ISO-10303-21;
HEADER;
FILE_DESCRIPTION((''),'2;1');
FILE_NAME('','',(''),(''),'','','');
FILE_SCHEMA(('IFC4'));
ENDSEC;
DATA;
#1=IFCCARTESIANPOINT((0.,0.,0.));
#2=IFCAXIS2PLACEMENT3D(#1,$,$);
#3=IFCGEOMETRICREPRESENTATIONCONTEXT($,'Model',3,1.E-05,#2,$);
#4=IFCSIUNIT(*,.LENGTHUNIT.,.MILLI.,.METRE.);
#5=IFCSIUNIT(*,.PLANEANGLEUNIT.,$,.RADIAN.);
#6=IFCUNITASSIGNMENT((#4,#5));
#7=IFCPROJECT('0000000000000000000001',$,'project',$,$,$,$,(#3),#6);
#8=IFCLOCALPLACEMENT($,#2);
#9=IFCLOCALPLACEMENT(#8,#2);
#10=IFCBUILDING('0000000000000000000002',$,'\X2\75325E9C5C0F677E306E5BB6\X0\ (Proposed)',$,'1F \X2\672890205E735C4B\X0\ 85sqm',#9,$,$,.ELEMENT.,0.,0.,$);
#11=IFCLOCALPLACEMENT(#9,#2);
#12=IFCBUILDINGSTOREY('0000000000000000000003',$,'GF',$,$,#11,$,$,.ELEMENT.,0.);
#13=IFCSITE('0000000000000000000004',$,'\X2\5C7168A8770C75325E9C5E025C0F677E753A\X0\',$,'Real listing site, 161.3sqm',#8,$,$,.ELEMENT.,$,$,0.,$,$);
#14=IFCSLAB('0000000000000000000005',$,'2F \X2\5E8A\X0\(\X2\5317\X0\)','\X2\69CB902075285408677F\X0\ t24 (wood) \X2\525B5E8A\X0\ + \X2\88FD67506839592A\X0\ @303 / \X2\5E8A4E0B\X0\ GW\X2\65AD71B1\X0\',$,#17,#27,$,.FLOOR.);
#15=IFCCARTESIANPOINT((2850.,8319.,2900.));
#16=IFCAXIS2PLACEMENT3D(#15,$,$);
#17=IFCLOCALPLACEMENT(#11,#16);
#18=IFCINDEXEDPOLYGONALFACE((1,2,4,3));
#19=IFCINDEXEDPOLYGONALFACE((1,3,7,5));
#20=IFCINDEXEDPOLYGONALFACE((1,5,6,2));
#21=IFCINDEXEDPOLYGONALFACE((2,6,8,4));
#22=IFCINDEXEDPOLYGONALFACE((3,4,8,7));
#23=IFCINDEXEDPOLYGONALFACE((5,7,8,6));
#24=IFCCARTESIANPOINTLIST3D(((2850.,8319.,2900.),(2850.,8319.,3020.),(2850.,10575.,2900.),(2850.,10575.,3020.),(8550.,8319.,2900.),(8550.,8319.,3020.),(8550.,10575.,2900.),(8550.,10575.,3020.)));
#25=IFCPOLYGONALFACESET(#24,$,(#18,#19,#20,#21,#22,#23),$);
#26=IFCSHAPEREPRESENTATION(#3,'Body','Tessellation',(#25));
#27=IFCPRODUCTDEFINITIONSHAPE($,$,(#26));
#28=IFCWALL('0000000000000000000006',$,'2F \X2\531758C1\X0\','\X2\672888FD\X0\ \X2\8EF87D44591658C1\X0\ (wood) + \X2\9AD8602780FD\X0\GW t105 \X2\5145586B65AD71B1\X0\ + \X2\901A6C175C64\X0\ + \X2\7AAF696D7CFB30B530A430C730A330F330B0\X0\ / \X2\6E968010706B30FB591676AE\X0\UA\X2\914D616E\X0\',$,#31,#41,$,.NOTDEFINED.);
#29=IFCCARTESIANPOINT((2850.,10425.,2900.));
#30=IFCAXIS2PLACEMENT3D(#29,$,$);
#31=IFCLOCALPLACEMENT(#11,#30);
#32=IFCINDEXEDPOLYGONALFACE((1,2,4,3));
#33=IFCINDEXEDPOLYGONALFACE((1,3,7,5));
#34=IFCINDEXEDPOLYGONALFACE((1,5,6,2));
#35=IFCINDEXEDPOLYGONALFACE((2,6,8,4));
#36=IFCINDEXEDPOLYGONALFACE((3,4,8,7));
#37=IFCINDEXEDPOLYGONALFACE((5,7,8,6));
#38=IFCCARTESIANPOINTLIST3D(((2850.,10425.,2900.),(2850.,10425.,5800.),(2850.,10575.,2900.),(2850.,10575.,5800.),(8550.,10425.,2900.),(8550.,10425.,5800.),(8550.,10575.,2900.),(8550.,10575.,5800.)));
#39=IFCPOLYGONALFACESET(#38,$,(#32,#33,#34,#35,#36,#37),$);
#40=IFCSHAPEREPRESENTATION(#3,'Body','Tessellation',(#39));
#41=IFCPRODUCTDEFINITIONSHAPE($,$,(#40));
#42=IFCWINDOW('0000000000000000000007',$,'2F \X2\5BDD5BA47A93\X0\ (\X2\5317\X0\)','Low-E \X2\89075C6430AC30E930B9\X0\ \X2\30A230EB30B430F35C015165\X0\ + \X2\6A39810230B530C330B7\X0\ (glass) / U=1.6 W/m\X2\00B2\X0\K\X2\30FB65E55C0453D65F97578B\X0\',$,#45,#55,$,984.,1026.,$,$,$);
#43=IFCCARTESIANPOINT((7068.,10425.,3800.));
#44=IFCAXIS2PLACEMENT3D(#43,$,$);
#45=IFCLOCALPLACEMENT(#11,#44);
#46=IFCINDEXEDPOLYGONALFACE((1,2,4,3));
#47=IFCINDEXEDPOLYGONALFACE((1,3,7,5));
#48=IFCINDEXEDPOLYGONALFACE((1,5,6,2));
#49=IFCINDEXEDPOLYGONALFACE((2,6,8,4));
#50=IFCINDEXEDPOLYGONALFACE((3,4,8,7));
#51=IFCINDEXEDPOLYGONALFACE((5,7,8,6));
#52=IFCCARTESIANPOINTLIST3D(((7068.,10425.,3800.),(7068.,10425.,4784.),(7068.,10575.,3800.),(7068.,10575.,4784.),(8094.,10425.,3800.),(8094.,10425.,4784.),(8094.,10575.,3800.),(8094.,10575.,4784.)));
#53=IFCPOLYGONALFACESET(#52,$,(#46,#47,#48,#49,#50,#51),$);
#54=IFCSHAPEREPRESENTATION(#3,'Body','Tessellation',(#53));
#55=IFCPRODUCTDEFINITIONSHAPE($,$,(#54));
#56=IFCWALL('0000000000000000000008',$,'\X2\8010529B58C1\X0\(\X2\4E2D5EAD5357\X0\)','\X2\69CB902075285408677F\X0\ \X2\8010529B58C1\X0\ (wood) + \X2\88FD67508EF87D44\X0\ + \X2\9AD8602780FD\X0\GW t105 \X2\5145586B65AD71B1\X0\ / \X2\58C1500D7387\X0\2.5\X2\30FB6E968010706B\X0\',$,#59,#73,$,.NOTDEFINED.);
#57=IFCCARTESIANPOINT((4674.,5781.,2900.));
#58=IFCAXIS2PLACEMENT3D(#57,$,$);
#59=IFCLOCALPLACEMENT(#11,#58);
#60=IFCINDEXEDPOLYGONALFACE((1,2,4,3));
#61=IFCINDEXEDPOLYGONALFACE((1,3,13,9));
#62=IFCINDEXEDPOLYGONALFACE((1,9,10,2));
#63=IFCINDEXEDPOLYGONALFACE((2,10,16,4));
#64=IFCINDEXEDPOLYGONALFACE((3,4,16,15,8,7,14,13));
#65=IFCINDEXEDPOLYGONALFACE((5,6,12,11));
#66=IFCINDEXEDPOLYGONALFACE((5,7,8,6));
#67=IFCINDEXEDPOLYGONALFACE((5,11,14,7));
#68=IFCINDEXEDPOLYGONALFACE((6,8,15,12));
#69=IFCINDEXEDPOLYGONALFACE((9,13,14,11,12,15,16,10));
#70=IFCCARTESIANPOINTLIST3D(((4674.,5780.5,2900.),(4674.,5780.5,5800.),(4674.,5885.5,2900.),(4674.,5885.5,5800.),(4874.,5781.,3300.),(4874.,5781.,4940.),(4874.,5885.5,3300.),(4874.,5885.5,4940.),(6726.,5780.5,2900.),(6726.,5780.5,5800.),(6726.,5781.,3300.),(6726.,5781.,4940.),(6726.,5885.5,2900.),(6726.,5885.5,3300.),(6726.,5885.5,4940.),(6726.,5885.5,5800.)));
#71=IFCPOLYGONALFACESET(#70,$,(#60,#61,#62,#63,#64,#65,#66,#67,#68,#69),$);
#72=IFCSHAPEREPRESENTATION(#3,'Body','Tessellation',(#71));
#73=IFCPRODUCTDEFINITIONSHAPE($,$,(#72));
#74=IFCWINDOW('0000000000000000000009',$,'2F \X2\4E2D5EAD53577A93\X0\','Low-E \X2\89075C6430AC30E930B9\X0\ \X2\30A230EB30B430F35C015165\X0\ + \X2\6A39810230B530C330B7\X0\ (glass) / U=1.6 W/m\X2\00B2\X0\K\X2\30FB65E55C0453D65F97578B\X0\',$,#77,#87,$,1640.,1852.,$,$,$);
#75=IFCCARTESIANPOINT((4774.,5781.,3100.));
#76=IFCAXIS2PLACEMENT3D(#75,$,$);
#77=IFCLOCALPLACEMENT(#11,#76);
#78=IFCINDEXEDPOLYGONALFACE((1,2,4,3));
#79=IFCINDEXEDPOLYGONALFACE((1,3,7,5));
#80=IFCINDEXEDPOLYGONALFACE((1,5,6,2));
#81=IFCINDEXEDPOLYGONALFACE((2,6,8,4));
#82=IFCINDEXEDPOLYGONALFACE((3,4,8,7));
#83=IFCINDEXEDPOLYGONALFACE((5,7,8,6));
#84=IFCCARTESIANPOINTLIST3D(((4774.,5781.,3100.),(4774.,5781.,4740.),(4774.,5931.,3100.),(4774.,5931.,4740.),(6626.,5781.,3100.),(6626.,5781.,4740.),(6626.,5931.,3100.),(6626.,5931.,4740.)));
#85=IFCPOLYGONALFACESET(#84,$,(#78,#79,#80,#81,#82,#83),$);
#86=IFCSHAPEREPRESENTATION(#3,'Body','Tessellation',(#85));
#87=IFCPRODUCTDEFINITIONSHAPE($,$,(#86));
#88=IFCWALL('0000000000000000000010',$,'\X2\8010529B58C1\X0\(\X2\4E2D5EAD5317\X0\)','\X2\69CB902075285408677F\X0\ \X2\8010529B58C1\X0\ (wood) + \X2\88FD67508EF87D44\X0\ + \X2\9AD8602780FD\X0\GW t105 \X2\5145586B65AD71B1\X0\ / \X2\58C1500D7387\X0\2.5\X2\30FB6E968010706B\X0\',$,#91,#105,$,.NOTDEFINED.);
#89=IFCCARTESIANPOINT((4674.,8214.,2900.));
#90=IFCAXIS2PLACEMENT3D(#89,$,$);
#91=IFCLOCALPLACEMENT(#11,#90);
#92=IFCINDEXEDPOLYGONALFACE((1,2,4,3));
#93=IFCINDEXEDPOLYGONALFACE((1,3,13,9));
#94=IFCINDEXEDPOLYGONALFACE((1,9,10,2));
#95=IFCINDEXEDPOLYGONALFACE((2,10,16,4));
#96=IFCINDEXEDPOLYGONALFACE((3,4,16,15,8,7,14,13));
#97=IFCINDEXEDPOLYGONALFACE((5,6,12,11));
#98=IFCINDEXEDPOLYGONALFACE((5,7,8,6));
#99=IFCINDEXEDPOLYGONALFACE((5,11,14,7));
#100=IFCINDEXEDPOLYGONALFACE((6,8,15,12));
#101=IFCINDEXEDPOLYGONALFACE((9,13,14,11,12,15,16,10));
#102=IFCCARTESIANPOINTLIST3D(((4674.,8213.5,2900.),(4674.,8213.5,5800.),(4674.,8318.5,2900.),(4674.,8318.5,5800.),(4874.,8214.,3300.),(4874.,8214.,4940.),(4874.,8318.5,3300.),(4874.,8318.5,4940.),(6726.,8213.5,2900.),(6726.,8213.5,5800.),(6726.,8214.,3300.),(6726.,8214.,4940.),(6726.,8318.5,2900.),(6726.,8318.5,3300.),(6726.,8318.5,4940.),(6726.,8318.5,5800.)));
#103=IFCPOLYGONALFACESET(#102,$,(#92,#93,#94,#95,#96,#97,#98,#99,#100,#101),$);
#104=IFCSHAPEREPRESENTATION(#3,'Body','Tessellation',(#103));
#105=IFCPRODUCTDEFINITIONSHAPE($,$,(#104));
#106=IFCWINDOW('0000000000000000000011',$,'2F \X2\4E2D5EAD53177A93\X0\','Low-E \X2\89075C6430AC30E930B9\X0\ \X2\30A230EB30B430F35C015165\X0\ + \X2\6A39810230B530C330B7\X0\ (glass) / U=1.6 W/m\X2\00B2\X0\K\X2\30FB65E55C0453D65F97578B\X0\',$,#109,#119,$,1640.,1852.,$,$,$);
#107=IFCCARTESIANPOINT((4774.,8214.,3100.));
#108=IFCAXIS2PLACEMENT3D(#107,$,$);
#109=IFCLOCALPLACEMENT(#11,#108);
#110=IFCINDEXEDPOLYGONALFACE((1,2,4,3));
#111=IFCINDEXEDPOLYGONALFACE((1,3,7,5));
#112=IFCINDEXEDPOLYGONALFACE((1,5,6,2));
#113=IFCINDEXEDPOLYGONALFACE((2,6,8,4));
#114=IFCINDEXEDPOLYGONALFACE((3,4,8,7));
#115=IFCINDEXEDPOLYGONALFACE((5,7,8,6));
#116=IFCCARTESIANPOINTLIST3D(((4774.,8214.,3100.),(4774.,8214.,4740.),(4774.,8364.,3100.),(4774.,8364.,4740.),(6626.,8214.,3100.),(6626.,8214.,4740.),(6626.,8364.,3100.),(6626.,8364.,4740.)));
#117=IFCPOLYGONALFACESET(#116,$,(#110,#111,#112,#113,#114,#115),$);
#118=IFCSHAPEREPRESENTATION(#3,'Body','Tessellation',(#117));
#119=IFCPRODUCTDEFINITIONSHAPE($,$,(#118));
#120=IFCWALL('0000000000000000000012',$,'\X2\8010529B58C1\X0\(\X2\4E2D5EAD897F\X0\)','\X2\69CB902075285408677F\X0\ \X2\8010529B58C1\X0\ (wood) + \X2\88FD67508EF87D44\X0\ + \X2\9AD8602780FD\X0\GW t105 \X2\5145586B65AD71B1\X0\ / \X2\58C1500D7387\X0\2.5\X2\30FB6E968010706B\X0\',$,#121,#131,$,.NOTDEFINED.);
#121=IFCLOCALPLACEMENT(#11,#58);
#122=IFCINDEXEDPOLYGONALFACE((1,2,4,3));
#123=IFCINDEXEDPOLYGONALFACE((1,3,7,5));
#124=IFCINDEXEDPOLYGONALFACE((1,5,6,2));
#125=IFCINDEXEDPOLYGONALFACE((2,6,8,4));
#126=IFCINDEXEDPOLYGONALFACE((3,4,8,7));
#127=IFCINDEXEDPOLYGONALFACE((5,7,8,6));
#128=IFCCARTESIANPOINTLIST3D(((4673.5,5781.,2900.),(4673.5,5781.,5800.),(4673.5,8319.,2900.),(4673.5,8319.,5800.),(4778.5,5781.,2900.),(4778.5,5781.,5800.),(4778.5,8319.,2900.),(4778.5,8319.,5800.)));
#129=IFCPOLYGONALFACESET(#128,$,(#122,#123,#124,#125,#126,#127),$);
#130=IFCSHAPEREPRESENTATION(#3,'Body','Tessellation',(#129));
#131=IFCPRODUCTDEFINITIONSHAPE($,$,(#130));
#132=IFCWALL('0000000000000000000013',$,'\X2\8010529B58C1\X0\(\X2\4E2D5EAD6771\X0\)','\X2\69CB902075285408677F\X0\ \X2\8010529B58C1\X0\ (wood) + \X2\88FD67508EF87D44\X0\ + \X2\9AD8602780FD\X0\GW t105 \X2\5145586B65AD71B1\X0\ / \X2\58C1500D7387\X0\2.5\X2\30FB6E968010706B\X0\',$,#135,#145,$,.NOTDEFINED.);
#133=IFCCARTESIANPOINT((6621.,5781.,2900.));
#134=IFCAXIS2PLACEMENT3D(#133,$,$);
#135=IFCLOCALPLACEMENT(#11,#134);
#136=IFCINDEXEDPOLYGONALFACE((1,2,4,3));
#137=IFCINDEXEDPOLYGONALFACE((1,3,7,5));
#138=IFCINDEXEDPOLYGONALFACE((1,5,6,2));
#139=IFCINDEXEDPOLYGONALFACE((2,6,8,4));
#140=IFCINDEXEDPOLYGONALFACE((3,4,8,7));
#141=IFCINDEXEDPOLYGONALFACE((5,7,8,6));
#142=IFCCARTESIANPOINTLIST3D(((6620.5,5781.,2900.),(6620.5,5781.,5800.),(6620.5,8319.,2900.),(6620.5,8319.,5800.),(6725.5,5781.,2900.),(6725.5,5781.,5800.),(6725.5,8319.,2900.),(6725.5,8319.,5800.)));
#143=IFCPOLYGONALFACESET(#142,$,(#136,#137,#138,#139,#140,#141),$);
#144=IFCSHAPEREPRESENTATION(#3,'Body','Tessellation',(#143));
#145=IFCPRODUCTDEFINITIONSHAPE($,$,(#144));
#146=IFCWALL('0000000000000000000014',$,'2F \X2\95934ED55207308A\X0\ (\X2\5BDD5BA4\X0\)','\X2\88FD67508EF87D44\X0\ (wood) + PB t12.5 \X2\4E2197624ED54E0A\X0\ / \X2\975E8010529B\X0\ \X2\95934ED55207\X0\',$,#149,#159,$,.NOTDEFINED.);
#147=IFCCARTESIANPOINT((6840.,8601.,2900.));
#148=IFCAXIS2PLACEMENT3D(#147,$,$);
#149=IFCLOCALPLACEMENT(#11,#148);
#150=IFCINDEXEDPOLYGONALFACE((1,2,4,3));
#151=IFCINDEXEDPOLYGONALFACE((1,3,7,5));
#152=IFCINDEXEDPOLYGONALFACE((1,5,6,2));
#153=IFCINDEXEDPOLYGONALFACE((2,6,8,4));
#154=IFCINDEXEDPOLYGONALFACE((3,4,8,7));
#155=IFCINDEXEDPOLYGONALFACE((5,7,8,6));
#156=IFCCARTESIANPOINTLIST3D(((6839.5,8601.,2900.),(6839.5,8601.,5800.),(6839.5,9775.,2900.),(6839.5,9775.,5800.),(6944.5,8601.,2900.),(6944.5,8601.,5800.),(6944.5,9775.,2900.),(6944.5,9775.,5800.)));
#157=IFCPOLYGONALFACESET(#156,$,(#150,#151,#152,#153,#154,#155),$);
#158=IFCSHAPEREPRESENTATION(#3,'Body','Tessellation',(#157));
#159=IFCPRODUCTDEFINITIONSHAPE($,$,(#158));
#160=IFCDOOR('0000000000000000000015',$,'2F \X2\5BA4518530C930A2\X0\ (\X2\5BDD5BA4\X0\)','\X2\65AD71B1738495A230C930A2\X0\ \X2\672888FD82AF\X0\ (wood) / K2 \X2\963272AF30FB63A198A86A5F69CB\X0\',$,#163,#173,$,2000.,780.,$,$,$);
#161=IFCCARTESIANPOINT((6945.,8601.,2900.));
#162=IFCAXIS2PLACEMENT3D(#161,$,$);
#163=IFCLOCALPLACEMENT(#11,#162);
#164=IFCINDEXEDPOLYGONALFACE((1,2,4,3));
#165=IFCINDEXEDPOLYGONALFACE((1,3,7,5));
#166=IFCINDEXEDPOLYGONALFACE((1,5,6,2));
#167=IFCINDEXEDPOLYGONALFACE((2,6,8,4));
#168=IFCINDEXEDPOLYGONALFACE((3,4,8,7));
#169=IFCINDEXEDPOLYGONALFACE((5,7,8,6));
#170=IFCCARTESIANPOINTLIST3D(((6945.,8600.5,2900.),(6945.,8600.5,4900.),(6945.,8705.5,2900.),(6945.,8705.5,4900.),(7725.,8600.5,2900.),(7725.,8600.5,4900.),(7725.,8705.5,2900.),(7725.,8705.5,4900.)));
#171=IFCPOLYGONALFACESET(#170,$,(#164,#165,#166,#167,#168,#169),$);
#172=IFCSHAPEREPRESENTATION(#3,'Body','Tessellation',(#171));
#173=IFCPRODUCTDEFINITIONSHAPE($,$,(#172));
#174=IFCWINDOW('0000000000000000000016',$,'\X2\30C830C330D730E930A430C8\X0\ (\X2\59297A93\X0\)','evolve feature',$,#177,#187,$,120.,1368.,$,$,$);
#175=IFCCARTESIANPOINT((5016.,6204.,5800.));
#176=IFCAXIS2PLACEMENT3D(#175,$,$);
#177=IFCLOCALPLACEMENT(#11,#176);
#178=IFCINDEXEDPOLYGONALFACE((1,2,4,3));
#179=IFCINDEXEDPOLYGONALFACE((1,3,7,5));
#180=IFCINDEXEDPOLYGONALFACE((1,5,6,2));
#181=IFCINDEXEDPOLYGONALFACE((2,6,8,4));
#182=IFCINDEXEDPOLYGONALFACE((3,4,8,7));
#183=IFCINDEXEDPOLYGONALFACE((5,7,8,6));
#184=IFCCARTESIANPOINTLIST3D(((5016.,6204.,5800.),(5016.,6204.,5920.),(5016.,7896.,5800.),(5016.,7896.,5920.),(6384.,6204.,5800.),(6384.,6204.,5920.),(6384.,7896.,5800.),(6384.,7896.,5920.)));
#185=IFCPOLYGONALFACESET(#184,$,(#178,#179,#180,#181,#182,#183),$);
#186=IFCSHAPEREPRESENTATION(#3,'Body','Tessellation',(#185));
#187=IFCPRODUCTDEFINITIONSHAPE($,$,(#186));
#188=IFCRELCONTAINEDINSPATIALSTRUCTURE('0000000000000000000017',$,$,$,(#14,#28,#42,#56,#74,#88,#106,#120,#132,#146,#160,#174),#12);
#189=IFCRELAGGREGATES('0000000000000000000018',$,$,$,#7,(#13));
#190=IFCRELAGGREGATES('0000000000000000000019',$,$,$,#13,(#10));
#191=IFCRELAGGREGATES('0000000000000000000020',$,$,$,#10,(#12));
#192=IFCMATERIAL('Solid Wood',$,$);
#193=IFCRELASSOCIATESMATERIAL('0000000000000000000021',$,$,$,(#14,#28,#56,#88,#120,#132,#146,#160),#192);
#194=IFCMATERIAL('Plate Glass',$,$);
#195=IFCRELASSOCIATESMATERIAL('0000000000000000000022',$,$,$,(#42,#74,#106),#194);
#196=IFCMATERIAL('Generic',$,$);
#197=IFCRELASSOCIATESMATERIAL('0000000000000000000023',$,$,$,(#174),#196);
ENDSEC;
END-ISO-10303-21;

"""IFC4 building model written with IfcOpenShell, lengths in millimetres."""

from ifc_helpers import new_model, si_unit, frame, frame_2d, origin, place, context, project, spatial, rectangle, extrude, material, element, fill, save


model = new_model("IFC4")

# Units and contexts
model_context = context("Model", 3, precision=1e-05, world=origin())
ifc_project = project(units=[si_unit("LENGTHUNIT", "METRE", prefix="MILLI"), si_unit("PLANEANGLEUNIT", "RADIAN")], contexts=[model_context])

# Site, building, storey
site_placement = place(None, origin())
site = spatial("IfcSite", under=ifc_project, at=site_placement, Name="山梨県甲府市小松町", ObjectType="Real listing site, 161.3sqm", CompositionType="ELEMENT", RefElevation=0.0)
building_placement = place(site_placement, origin())
building = spatial("IfcBuilding", under=site, at=building_placement, Name="甲府小松の家 (Proposed)", ObjectType="1F 木造平屋 85sqm", CompositionType="ELEMENT", ElevationOfRefHeight=0.0, ElevationOfTerrain=0.0)
storey_placement = place(building_placement, origin())
storey = spatial("IfcBuildingStorey", under=building, at=storey_placement, Name="GF", CompositionType="ELEMENT", Elevation=0.0)

# Slab
ifc_material_1 = material(Name="Solid Wood")
slab_placement = place(storey_placement, frame((2850.0, 8319.0, 2900.0)))
element("IfcSlab", 1, at=slab_placement, inside=storey, material=ifc_material_1, Name="2F 床(北)", Description="構造用合板 t24 (wood) 剛床 + 製材根太 @303 / 床下 GW断熱", PredefinedType="FLOOR", context=model_context, shape_type="SweptSolid", body=[
    extrude(rectangle(XDim=5700.0, YDim=2256.0, at=frame_2d((2850.0, 1128.0))), frame((2850.0, 8319.0, 2900.0)), (0.0, 0.0, 1.0), 120.0),
])

# Walls, openings, windows
wall_1_placement = place(storey_placement, frame((2850.0, 10425.0, 2900.0)))
wall_1 = element("IfcWall", 2, at=wall_1_placement, inside=storey, material=ifc_material_1, Name="2F 北壁", Description="木製 軸組外壁 (wood) + 高性能GW t105 充填断熱 + 通気層 + 窯業系サイディング / 準耐火・外皮UA配慮", PredefinedType="NOTDEFINED", context=model_context, shape_type="SweptSolid", body=[
    extrude(rectangle(XDim=5700.0, YDim=150.0, at=frame_2d((2850.0, 75.0))), frame((2850.0, 10425.0, 2900.0)), (0.0, 0.0, 1.0), 2900.0),
])
opening_1_placement = place(storey_placement, frame((7068.0, 10425.0, 3800.0)))
opening_1 = element("IfcOpeningElement", 3, at=opening_1_placement, cuts=wall_1, PredefinedType="NOTDEFINED", context=model_context, shape_type="SweptSolid", body=[
    extrude(rectangle(XDim=1026.0, YDim=150.0, at=frame_2d((513.0, 75.0))), frame((7068.0, 10425.0, 3800.0)), (0.0, 0.0, 1.0), 984.0),
])
ifc_material_2 = material(Name="Plate Glass")
window_1_placement = place(storey_placement, frame((7068.0, 10425.0, 3800.0)))
window_1 = element("IfcWindow", 4, at=window_1_placement, inside=storey, material=ifc_material_2, Name="2F 寝室窓 (北)", Description="Low-E 複層ガラス アルゴン封入 + 樹脂サッシ (glass) / U=1.6 W/m²K・日射取得型", OverallHeight=984.0, OverallWidth=1026.0, context=model_context, shape_type="SweptSolid", body=[
    extrude(rectangle(XDim=1026.0, YDim=150.0, at=frame_2d((513.0, 75.0))), frame((7068.0, 10425.0, 3800.0)), (0.0, 0.0, 1.0), 984.0),
])
fill(opening_1, window_1)
wall_2_placement = place(storey_placement, frame((4674.0, 5781.0, 2900.0)))
wall_2 = element("IfcWall", 5, at=wall_2_placement, inside=storey, material=ifc_material_1, Name="耐力壁(中庭南)", Description="構造用合板 耐力壁 (wood) + 製材軸組 + 高性能GW t105 充填断熱 / 壁倍率2.5・準耐火", PredefinedType="NOTDEFINED", context=model_context, shape_type="SweptSolid", body=[
    extrude(rectangle(XDim=2052.0, YDim=105.0, at=frame_2d((1026.0, 52.0))), frame((4674.0, 5781.0, 2900.0)), (0.0, 0.0, 1.0), 2900.0),
])
opening_2_placement = place(storey_placement, frame((4774.0, 5781.0, 3100.0)))
opening_2 = element("IfcOpeningElement", 6, at=opening_2_placement, cuts=wall_2, PredefinedType="NOTDEFINED", context=model_context, shape_type="SweptSolid", body=[
    extrude(rectangle(XDim=1852.0, YDim=150.0, at=frame_2d((926.0, 75.0))), frame((4774.0, 5781.0, 3100.0)), (0.0, 0.0, 1.0), 1640.0),
])
window_2_placement = place(storey_placement, frame((4774.0, 5781.0, 3100.0)))
window_2 = element("IfcWindow", 7, at=window_2_placement, inside=storey, material=ifc_material_2, Name="2F 中庭南窓", Description="Low-E 複層ガラス アルゴン封入 + 樹脂サッシ (glass) / U=1.6 W/m²K・日射取得型", OverallHeight=1640.0, OverallWidth=1852.0, context=model_context, shape_type="SweptSolid", body=[
    extrude(rectangle(XDim=1852.0, YDim=150.0, at=frame_2d((926.0, 75.0))), frame((4774.0, 5781.0, 3100.0)), (0.0, 0.0, 1.0), 1640.0),
])
fill(opening_2, window_2)
wall_3_placement = place(storey_placement, frame((4674.0, 8214.0, 2900.0)))
wall_3 = element("IfcWall", 8, at=wall_3_placement, inside=storey, material=ifc_material_1, Name="耐力壁(中庭北)", Description="構造用合板 耐力壁 (wood) + 製材軸組 + 高性能GW t105 充填断熱 / 壁倍率2.5・準耐火", PredefinedType="NOTDEFINED", context=model_context, shape_type="SweptSolid", body=[
    extrude(rectangle(XDim=2052.0, YDim=105.0, at=frame_2d((1026.0, 52.0))), frame((4674.0, 8214.0, 2900.0)), (0.0, 0.0, 1.0), 2900.0),
])
opening_3_placement = place(storey_placement, frame((4774.0, 8214.0, 3100.0)))
opening_3 = element("IfcOpeningElement", 9, at=opening_3_placement, cuts=wall_3, PredefinedType="NOTDEFINED", context=model_context, shape_type="SweptSolid", body=[
    extrude(rectangle(XDim=1852.0, YDim=150.0, at=frame_2d((926.0, 75.0))), frame((4774.0, 8214.0, 3100.0)), (0.0, 0.0, 1.0), 1640.0),
])
window_3_placement = place(storey_placement, frame((4774.0, 8214.0, 3100.0)))
window_3 = element("IfcWindow", 10, at=window_3_placement, inside=storey, material=ifc_material_2, Name="2F 中庭北窓", Description="Low-E 複層ガラス アルゴン封入 + 樹脂サッシ (glass) / U=1.6 W/m²K・日射取得型", OverallHeight=1640.0, OverallWidth=1852.0, context=model_context, shape_type="SweptSolid", body=[
    extrude(rectangle(XDim=1852.0, YDim=150.0, at=frame_2d((926.0, 75.0))), frame((4774.0, 8214.0, 3100.0)), (0.0, 0.0, 1.0), 1640.0),
])
fill(opening_3, window_3)

# Walls
wall_4_placement = place(storey_placement, frame((4674.0, 5781.0, 2900.0)))
element("IfcWall", 11, at=wall_4_placement, inside=storey, material=ifc_material_1, Name="耐力壁(中庭西)", Description="構造用合板 耐力壁 (wood) + 製材軸組 + 高性能GW t105 充填断熱 / 壁倍率2.5・準耐火", PredefinedType="NOTDEFINED", context=model_context, shape_type="SweptSolid", body=[
    extrude(rectangle(XDim=105.0, YDim=2538.0, at=frame_2d((52.0, 1269.0))), frame((4674.0, 5781.0, 2900.0)), (0.0, 0.0, 1.0), 2900.0),
])
wall_5_placement = place(storey_placement, frame((6621.0, 5781.0, 2900.0)))
element("IfcWall", 12, at=wall_5_placement, inside=storey, material=ifc_material_1, Name="耐力壁(中庭東)", Description="構造用合板 耐力壁 (wood) + 製材軸組 + 高性能GW t105 充填断熱 / 壁倍率2.5・準耐火", PredefinedType="NOTDEFINED", context=model_context, shape_type="SweptSolid", body=[
    extrude(rectangle(XDim=105.0, YDim=2538.0, at=frame_2d((52.0, 1269.0))), frame((6621.0, 5781.0, 2900.0)), (0.0, 0.0, 1.0), 2900.0),
])
wall_6_placement = place(storey_placement, frame((6840.0, 8601.0, 2900.0)))
element("IfcWall", 13, at=wall_6_placement, inside=storey, material=ifc_material_1, Name="2F 間仕切り (寝室)", Description="製材軸組 (wood) + PB t12.5 両面仕上 / 非耐力 間仕切", PredefinedType="NOTDEFINED", context=model_context, shape_type="SweptSolid", body=[
    extrude(rectangle(XDim=105.0, YDim=1174.0, at=frame_2d((52.0, 587.0))), frame((6840.0, 8601.0, 2900.0)), (0.0, 0.0, 1.0), 2900.0),
])

# Door
door_placement = place(storey_placement, frame((6945.0, 8601.0, 2900.0)))
element("IfcDoor", 14, at=door_placement, inside=storey, material=ifc_material_1, Name="2F 室内ドア (寝室)", Description="断熱玄関ドア 木製芯 (wood) / K2 防犯・採風機構", OverallHeight=2000.0, OverallWidth=780.0, context=model_context, shape_type="SweptSolid", body=[
    extrude(rectangle(XDim=780.0, YDim=105.0, at=frame_2d((390.0, 52.0))), frame((6945.0, 8601.0, 2900.0)), (0.0, 0.0, 1.0), 2000.0),
])

# Window
ifc_material_3 = material(Name="Generic")
window_4_placement = place(storey_placement, frame((5016.0, 6204.0, 5800.0)))
element("IfcWindow", 15, at=window_4_placement, inside=storey, material=ifc_material_3, Name="トップライト (天窓)", Description="evolve feature", OverallHeight=120.0, OverallWidth=1368.0, context=model_context, shape_type="SweptSolid", body=[
    extrude(rectangle(XDim=1368.0, YDim=1692.0, at=frame_2d((684.0, 846.0))), frame((5016.0, 6204.0, 5800.0)), (0.0, 0.0, 1.0), 120.0),
])

save(model, "model.ifc")
